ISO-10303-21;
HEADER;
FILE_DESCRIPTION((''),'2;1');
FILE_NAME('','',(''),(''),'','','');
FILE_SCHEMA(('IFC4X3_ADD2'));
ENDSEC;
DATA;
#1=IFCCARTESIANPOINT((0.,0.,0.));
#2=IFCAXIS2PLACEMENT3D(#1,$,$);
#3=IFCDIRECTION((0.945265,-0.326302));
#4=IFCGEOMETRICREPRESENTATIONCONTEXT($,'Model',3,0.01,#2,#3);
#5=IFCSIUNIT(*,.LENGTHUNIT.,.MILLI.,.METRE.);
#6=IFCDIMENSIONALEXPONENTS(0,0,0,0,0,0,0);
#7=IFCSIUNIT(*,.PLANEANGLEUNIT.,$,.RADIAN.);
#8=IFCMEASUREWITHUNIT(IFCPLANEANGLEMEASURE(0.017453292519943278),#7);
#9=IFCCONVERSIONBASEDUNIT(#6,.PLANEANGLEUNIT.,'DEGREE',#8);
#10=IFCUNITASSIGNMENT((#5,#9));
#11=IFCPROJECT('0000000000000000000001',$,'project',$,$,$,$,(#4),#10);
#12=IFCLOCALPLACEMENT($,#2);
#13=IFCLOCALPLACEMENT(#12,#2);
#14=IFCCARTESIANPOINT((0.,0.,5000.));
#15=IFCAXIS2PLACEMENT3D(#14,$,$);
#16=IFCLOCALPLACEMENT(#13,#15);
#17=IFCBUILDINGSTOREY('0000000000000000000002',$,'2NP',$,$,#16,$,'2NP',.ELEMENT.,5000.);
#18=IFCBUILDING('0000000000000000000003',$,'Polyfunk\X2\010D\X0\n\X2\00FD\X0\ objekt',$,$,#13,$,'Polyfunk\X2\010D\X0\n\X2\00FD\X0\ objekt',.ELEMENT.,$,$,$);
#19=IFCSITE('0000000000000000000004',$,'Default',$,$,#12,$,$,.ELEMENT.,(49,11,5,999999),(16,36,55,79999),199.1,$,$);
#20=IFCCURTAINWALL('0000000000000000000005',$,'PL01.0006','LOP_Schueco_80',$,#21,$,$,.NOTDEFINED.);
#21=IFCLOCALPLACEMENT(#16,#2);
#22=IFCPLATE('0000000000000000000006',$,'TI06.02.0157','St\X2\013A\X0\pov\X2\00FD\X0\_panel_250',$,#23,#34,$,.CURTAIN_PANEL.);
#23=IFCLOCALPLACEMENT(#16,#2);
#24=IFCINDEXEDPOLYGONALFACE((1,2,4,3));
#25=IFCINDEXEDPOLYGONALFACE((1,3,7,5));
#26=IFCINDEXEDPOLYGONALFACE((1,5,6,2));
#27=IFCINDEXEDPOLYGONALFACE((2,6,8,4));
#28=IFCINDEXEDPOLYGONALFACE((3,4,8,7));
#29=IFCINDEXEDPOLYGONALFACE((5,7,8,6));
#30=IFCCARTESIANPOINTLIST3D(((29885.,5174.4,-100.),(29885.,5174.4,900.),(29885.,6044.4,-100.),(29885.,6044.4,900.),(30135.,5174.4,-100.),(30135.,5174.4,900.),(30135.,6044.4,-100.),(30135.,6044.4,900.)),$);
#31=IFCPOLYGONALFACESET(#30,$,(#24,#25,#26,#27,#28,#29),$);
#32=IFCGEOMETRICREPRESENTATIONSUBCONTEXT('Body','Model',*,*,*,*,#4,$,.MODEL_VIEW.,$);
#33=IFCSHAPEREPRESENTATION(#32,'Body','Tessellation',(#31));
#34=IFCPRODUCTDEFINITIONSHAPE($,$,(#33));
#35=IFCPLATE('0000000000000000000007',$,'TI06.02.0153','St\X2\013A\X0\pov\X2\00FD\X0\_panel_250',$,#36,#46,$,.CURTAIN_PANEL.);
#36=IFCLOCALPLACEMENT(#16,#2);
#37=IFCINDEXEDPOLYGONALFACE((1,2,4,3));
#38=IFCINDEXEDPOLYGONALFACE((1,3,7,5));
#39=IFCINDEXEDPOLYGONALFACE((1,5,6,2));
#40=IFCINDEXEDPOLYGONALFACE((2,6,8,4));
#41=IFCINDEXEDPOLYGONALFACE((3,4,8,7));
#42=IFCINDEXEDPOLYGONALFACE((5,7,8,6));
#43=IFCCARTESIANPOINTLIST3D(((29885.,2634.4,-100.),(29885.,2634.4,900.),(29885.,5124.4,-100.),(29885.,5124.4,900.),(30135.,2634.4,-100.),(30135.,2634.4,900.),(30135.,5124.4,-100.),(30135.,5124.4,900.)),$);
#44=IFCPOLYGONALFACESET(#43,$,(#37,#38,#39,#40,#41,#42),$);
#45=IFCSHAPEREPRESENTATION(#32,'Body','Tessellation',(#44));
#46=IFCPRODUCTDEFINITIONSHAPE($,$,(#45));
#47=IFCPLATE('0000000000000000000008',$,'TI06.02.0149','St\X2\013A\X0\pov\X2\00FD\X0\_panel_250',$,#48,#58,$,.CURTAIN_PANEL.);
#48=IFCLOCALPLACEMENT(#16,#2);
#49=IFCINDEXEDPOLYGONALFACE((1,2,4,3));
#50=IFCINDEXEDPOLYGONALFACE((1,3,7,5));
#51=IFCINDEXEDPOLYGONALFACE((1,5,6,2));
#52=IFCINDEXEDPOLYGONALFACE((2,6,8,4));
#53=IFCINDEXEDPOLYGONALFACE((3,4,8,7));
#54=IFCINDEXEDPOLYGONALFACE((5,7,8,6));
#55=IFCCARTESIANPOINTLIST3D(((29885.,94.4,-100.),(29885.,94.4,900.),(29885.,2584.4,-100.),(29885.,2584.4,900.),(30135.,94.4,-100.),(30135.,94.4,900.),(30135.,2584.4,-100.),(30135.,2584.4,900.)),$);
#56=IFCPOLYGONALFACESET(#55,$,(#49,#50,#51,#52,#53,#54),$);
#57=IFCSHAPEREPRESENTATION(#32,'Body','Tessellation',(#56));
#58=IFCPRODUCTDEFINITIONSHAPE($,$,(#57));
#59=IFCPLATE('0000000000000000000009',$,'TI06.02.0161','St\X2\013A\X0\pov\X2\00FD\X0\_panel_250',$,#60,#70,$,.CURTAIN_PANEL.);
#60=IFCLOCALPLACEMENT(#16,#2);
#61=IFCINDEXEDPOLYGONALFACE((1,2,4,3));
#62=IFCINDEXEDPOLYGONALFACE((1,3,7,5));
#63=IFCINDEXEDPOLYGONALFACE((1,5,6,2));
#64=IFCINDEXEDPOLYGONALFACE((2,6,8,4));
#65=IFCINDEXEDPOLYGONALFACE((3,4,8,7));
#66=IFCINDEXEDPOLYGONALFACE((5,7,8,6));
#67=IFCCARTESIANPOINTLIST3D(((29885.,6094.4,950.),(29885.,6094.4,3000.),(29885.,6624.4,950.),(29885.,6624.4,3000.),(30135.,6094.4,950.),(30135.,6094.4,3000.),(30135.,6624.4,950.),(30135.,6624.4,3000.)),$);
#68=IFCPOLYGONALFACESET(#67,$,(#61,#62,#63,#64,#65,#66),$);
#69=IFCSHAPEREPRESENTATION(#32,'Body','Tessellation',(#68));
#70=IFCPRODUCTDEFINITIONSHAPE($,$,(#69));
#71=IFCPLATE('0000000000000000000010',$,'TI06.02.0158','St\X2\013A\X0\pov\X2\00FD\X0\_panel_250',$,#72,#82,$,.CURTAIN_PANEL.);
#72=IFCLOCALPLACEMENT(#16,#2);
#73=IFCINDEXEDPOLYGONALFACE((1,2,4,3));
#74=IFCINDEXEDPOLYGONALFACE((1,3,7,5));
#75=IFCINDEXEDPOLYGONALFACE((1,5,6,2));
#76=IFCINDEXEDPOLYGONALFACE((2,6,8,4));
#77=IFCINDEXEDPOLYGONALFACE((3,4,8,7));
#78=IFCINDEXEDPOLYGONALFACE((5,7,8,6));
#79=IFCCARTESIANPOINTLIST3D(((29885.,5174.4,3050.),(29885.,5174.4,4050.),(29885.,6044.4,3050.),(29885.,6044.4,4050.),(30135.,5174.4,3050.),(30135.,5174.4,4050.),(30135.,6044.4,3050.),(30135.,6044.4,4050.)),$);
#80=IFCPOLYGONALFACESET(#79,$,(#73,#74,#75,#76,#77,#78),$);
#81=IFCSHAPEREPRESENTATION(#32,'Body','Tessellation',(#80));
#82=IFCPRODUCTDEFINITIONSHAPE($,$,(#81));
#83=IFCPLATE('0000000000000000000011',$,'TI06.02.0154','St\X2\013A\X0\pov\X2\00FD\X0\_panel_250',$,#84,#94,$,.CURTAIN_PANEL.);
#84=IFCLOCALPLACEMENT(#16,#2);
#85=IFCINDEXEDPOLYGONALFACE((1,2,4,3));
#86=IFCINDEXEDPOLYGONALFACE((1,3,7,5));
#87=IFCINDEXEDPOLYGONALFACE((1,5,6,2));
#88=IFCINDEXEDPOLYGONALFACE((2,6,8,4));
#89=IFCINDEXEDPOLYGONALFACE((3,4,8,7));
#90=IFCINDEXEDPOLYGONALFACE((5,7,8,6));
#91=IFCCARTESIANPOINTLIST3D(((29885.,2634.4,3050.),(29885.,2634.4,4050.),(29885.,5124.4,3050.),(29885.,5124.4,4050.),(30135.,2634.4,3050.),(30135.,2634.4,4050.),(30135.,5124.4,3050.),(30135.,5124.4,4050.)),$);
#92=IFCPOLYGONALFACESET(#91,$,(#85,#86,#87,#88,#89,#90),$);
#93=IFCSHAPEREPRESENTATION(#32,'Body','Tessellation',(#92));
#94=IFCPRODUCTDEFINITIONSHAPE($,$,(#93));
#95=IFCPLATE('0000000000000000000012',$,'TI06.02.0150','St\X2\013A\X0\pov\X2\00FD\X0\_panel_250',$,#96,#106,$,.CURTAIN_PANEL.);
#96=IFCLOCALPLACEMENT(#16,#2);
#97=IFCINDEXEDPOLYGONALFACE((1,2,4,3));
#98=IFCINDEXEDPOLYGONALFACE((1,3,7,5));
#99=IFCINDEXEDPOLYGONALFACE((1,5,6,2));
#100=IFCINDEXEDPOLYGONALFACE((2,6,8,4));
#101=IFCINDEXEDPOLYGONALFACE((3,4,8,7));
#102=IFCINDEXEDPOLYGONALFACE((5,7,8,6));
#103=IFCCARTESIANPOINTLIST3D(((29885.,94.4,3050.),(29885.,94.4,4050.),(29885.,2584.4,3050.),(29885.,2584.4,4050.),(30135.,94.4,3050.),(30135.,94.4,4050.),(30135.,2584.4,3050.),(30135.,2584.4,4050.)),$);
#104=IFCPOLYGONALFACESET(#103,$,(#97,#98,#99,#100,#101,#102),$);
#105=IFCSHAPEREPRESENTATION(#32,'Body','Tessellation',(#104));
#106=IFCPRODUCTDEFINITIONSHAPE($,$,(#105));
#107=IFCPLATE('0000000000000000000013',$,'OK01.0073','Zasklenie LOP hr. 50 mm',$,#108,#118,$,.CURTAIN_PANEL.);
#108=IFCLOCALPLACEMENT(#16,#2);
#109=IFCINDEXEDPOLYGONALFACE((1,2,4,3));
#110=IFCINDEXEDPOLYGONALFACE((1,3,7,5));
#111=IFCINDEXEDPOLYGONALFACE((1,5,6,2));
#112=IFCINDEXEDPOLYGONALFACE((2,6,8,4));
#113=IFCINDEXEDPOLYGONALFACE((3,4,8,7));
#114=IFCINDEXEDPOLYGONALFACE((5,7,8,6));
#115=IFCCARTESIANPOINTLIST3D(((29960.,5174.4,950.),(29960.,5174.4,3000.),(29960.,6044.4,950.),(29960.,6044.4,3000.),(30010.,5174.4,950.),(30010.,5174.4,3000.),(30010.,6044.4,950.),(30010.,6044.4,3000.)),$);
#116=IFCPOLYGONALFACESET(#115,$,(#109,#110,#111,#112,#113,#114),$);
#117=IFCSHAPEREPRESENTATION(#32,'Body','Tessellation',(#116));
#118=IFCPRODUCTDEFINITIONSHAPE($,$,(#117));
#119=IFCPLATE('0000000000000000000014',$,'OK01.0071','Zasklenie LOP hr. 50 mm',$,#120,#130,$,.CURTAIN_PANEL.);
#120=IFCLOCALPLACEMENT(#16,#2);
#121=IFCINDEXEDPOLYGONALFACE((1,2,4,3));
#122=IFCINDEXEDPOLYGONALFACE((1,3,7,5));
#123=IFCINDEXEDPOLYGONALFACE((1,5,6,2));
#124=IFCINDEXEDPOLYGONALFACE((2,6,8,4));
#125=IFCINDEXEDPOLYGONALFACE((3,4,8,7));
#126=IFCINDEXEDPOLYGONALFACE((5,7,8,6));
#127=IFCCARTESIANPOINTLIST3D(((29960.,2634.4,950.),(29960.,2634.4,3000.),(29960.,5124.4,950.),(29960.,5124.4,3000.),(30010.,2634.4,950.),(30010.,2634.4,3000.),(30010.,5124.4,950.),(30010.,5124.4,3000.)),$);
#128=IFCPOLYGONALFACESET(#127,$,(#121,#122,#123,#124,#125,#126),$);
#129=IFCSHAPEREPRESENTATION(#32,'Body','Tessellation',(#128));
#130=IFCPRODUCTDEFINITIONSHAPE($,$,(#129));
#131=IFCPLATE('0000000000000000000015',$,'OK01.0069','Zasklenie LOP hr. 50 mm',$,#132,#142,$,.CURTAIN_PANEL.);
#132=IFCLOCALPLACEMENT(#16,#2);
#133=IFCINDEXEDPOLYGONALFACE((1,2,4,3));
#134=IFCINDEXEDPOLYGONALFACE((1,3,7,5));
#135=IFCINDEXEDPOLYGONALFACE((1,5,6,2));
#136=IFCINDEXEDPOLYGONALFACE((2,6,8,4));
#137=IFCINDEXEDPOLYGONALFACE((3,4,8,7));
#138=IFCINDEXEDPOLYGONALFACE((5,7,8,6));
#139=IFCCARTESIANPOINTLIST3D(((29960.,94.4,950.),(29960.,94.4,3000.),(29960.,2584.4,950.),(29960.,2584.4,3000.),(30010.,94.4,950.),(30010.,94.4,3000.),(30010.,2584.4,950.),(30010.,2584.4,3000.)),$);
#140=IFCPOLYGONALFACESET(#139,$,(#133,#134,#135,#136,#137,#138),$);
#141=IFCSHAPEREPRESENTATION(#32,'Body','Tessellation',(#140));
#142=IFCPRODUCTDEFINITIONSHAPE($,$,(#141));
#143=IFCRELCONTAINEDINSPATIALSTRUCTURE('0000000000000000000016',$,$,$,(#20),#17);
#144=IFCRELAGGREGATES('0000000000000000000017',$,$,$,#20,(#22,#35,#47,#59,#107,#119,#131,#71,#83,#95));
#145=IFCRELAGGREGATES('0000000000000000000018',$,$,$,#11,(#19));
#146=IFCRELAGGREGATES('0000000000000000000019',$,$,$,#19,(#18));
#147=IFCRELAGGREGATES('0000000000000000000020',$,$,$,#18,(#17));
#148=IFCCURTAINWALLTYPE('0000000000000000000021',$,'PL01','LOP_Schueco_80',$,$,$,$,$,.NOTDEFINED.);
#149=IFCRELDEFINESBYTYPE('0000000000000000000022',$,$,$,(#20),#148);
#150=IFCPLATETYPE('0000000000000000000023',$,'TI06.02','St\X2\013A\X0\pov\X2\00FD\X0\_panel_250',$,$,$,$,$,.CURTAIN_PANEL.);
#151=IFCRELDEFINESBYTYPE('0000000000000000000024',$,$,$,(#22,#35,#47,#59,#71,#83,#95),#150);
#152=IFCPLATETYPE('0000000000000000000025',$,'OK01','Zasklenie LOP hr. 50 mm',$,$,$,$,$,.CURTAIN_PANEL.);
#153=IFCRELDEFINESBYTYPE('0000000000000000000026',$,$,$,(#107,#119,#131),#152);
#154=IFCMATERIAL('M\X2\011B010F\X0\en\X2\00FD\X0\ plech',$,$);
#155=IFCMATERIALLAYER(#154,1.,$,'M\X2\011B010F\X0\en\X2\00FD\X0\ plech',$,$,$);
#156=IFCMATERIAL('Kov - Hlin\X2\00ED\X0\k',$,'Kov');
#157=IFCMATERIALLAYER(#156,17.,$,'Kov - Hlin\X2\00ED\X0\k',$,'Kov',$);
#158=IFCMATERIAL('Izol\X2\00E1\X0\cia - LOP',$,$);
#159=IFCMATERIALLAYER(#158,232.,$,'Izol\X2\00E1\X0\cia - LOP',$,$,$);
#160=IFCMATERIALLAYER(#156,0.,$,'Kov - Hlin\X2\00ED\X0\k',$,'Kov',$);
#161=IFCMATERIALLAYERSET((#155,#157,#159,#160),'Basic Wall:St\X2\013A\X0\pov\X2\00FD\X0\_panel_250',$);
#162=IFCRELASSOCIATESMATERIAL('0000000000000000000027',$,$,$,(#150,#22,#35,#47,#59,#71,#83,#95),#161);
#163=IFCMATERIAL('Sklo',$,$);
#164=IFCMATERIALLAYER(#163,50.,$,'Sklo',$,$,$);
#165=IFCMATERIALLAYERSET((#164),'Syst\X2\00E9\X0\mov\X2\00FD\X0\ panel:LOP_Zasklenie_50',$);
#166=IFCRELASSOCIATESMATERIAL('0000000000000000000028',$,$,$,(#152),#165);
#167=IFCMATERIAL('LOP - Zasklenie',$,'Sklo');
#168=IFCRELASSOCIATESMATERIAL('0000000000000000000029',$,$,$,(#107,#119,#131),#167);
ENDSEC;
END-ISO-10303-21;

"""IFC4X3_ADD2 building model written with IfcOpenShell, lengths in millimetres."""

from ifc_helpers import new_model, entity, si_unit, converted_unit, direction, frame, frame_2d, origin, origin_2d_with_axis, place, context, subcontext, project, spatial, rectangle, extrude, source, transform, mapped, material, layer, layer_set, layer_usage, type_object, type_shapes, element, aggregate, save


model = new_model("IFC4X3_ADD2")

# Units and contexts
model_context = context("Model", 3, precision=0.01, world=origin(), true_north=direction((0.945265, -0.326302)))
body_context = subcontext(model_context, "Body", "Model", "MODEL_VIEW")
ifc_project = project(units=[si_unit("LENGTHUNIT", "METRE", prefix="MILLI"), converted_unit("PLANEANGLEUNIT", "DEGREE", entity("IfcPlaneAngleMeasure", 0.017453292519943278), si_unit("PLANEANGLEUNIT", "RADIAN"), dimensions=[0, 0, 0, 0, 0, 0, 0])], contexts=[model_context])

# Site, building, storey
site_placement = place(None, origin())
site = spatial("IfcSite", under=ifc_project, at=site_placement, Name="Default", CompositionType="ELEMENT", RefLatitude=(49, 11, 5, 999999), RefLongitude=(16, 36, 55, 79999), RefElevation=199.1)
building_placement = place(site_placement, origin())
building = spatial("IfcBuilding", under=site, at=building_placement, Name="Polyfunkčný objekt", LongName="Polyfunkčný objekt", CompositionType="ELEMENT")
storey_placement = place(building_placement, frame((0.0, 0.0, 5000.0)))
storey = spatial("IfcBuildingStorey", under=building, at=storey_placement, Name="2NP", LongName="2NP", CompositionType="ELEMENT", Elevation=5000.0)

# Shared definitions
curtain_wall_type = type_object("IfcCurtainWallType", Name="PL01", Description="LOP_Schueco_80", PredefinedType="NOTDEFINED")

# Curtain wall
curtain_wall_1_placement = place(storey_placement, frame((0.0, 0.0, -5000.0)))
curtain_wall_1 = element("IfcCurtainWall", 1, at=curtain_wall_1_placement, inside=storey, type_object=curtain_wall_type, Name="PL01.0006", Description="LOP_Schueco_80", PredefinedType="NOTDEFINED")

# Plates
ifc_material_1 = material(Name="Měďený plech")
ifc_layer_1 = layer(ifc_material_1, 1.0, Name="Měďený plech")
ifc_material_2 = material(Name="Kov - Hliník", Category="Kov")
ifc_layer_2 = layer(ifc_material_2, 17.0, Name="Kov - Hliník", Category="Kov")
ifc_material_3 = material(Name="Izolácia - LOP")
ifc_layer_3 = layer(ifc_material_3, 232.0, Name="Izolácia - LOP")
ifc_layer_4 = layer(ifc_material_2, 0.0, Name="Kov - Hliník", Category="Kov")
ifc_layer_set_1 = layer_set([ifc_layer_1, ifc_layer_2, ifc_layer_3, ifc_layer_4], Name="Basic Wall:Stĺpový_panel_250")
ifc_layer_usage_1 = layer_usage(ifc_layer_set_1, "AXIS2", "POSITIVE", -125.0)
plate_type_1 = type_object("IfcPlateType", Name="TI06.02", Description="Stĺpový_panel_250", PredefinedType="CURTAIN_PANEL", material=ifc_layer_set_1)
plate_1_placement = place(storey_placement, frame((30010.0, 6044.4, -100.0), z_axis=(0.0, 0.0, 1.0), x_axis=(0.0, -1.0, 0.0)))
plate_1 = element("IfcPlate", 2, at=plate_1_placement, type_object=plate_type_1, material=ifc_layer_usage_1, Name="TI06.02.0157", Description="Stĺpový_panel_250", PredefinedType="CURTAIN_PANEL", context=body_context, shape_type="SweptSolid", body=[
    extrude(rectangle(XDim=250.0, YDim=870.0, at=frame_2d((0.0, 0.0), x_axis=(1.0, 0.0))), frame((435.0, 0.0, 0.0), z_axis=(0.0, 0.0, 1.0), x_axis=(0.0, 1.0, 0.0)), (0.0, 0.0, 1.0), 1000.0),
])
ifc_layer_usage_2 = layer_usage(ifc_layer_set_1, "AXIS2", "POSITIVE", -125.0)
plate_2_placement = place(storey_placement, frame((30010.0, 5124.4, -100.0), z_axis=(0.0, 0.0, 1.0), x_axis=(0.0, -1.0, 0.0)))
plate_2 = element("IfcPlate", 3, at=plate_2_placement, type_object=plate_type_1, material=ifc_layer_usage_2, Name="TI06.02.0153", Description="Stĺpový_panel_250", PredefinedType="CURTAIN_PANEL", context=body_context, shape_type="SweptSolid", body=[
    extrude(rectangle(XDim=250.0, YDim=2490.0, at=frame_2d((0.0, 0.0), x_axis=(1.0, 0.0))), frame((1245.0, 0.0, 0.0), z_axis=(0.0, 0.0, 1.0), x_axis=(0.0, 1.0, 0.0)), (0.0, 0.0, 1.0), 1000.0),
])
ifc_layer_usage_3 = layer_usage(ifc_layer_set_1, "AXIS2", "POSITIVE", -125.0)
plate_3_placement = place(storey_placement, frame((30010.0, 2584.4, -100.0), z_axis=(0.0, 0.0, 1.0), x_axis=(0.0, -1.0, 0.0)))
plate_3 = element("IfcPlate", 4, at=plate_3_placement, type_object=plate_type_1, material=ifc_layer_usage_3, Name="TI06.02.0149", Description="Stĺpový_panel_250", PredefinedType="CURTAIN_PANEL", context=body_context, shape_type="SweptSolid", body=[
    extrude(rectangle(XDim=250.0, YDim=2490.0, at=frame_2d((0.0, 0.0), x_axis=(1.0, 0.0))), frame((1245.0, 0.0, 0.0), z_axis=(0.0, 0.0, 1.0), x_axis=(0.0, 1.0, 0.0)), (0.0, 0.0, 1.0), 1000.0),
])
ifc_layer_usage_4 = layer_usage(ifc_layer_set_1, "AXIS2", "POSITIVE", -125.0)
plate_4_placement = place(storey_placement, frame((30010.0, 6624.4, 950.0), z_axis=(0.0, 0.0, 1.0), x_axis=(0.0, -1.0, 0.0)))
plate_4 = element("IfcPlate", 5, at=plate_4_placement, type_object=plate_type_1, material=ifc_layer_usage_4, Name="TI06.02.0161", Description="Stĺpový_panel_250", PredefinedType="CURTAIN_PANEL", context=body_context, shape_type="SweptSolid", body=[
    extrude(rectangle(XDim=250.0, YDim=530.0, at=frame_2d((0.0, 0.0), x_axis=(1.0, 0.0))), frame((265.0, 0.0, 0.0), z_axis=(0.0, 0.0, 1.0), x_axis=(0.0, 1.0, 0.0)), (0.0, 0.0, 1.0), 2050.0),
])
ifc_layer_usage_5 = layer_usage(ifc_layer_set_1, "AXIS2", "POSITIVE", -125.0)
plate_5_placement = place(storey_placement, frame((30010.0, 6044.4, 3050.0), z_axis=(0.0, 0.0, 1.0), x_axis=(0.0, -1.0, 0.0)))
plate_5 = element("IfcPlate", 6, at=plate_5_placement, type_object=plate_type_1, material=ifc_layer_usage_5, Name="TI06.02.0158", Description="Stĺpový_panel_250", PredefinedType="CURTAIN_PANEL", context=body_context, shape_type="SweptSolid", body=[
    extrude(rectangle(XDim=250.0, YDim=870.0, at=frame_2d((0.0, 0.0), x_axis=(1.0, 0.0))), frame((435.0, 0.0, 0.0), z_axis=(0.0, 0.0, 1.0), x_axis=(0.0, 1.0, 0.0)), (0.0, 0.0, 1.0), 1000.0),
])
ifc_layer_usage_6 = layer_usage(ifc_layer_set_1, "AXIS2", "POSITIVE", -125.0)
plate_6_placement = place(storey_placement, frame((30010.0, 5124.4, 3050.0), z_axis=(0.0, 0.0, 1.0), x_axis=(0.0, -1.0, 0.0)))
plate_6 = element("IfcPlate", 7, at=plate_6_placement, type_object=plate_type_1, material=ifc_layer_usage_6, Name="TI06.02.0154", Description="Stĺpový_panel_250", PredefinedType="CURTAIN_PANEL", context=body_context, shape_type="SweptSolid", body=[
    extrude(rectangle(XDim=250.0, YDim=2490.0, at=frame_2d((0.0, 0.0), x_axis=(1.0, 0.0))), frame((1245.0, 0.0, 0.0), z_axis=(0.0, 0.0, 1.0), x_axis=(0.0, 1.0, 0.0)), (0.0, 0.0, 1.0), 1000.0),
])
ifc_layer_usage_7 = layer_usage(ifc_layer_set_1, "AXIS2", "POSITIVE", -125.0)
plate_7_placement = place(storey_placement, frame((30010.0, 2584.4, 3050.0), z_axis=(0.0, 0.0, 1.0), x_axis=(0.0, -1.0, 0.0)))
plate_7 = element("IfcPlate", 8, at=plate_7_placement, type_object=plate_type_1, material=ifc_layer_usage_7, Name="TI06.02.0150", Description="Stĺpový_panel_250", PredefinedType="CURTAIN_PANEL", context=body_context, shape_type="SweptSolid", body=[
    extrude(rectangle(XDim=250.0, YDim=2490.0, at=frame_2d((0.0, 0.0), x_axis=(1.0, 0.0))), frame((1245.0, 0.0, 0.0), z_axis=(0.0, 0.0, 1.0), x_axis=(0.0, 1.0, 0.0)), (0.0, 0.0, 1.0), 1000.0),
])
ifc_material_4 = material(Name="LOP - Zasklenie", Category="Sklo")
ifc_material_5 = material(Name="Sklo")
ifc_layer_5 = layer(ifc_material_5, 50.0, Name="Sklo")
ifc_layer_set_2 = layer_set([ifc_layer_5], Name="Systémový panel:LOP_Zasklenie_50")
plate_type_2 = type_object("IfcPlateType", Name="OK01", Description="Zasklenie LOP hr. 50 mm", PredefinedType="CURTAIN_PANEL", material=ifc_layer_set_2)
shared_shape_1 = source(origin(), body_context, "Body", "SweptSolid", [
    extrude(rectangle(XDim=50.0, YDim=870.0, at=origin_2d_with_axis()), frame((0.0, -25.0, 0.0), z_axis=(0.0, 0.0, 1.0), x_axis=(0.0, 1.0, 0.0)), (0.0, 0.0, 1.0), 2050.0),
])
plate_8_placement = place(curtain_wall_1_placement, frame((30010.0, 5609.4, 5950.0), z_axis=(0.0, 0.0, 1.0), x_axis=(0.0, -1.0, 0.0)))
plate_8 = element("IfcPlate", 9, at=plate_8_placement, type_object=plate_type_2, material=ifc_material_4, Name="OK01.0073", Description="Zasklenie LOP hr. 50 mm", PredefinedType="CURTAIN_PANEL", context=body_context, shape_type="MappedRepresentation", body=[
    mapped(shared_shape_1, transform((0.0, 0.0, 0.0), scale=1.0)),
])
shared_shape_2 = source(origin(), body_context, "Body", "SweptSolid", [
    extrude(rectangle(XDim=50.0, YDim=2490.0, at=origin_2d_with_axis()), frame((0.0, -25.0, 0.0), z_axis=(0.0, 0.0, 1.0), x_axis=(0.0, 1.0, 0.0)), (0.0, 0.0, 1.0), 2050.0),
])
type_shapes(plate_type_2, [shared_shape_1, shared_shape_2])
plate_9_placement = place(curtain_wall_1_placement, frame((30010.0, 3879.4, 5950.0), z_axis=(0.0, 0.0, 1.0), x_axis=(0.0, -1.0, 0.0)))
plate_9 = element("IfcPlate", 10, at=plate_9_placement, type_object=plate_type_2, material=ifc_material_4, Name="OK01.0071", Description="Zasklenie LOP hr. 50 mm", PredefinedType="CURTAIN_PANEL", context=body_context, shape_type="MappedRepresentation", body=[
    mapped(shared_shape_2, transform((0.0, 0.0, 0.0), scale=1.0)),
])
plate_10_placement = place(curtain_wall_1_placement, frame((30010.0, 1339.4, 5950.0), z_axis=(0.0, 0.0, 1.0), x_axis=(0.0, -1.0, 0.0)))
plate_10 = element("IfcPlate", 11, at=plate_10_placement, type_object=plate_type_2, material=ifc_material_4, Name="OK01.0069", Description="Zasklenie LOP hr. 50 mm", PredefinedType="CURTAIN_PANEL", context=body_context, shape_type="MappedRepresentation", body=[
    mapped(shared_shape_2, transform((0.0, 0.0, 0.0), scale=1.0)),
])
aggregate(curtain_wall_1, [plate_1, plate_2, plate_3, plate_4, plate_8, plate_9, plate_10, plate_5, plate_6, plate_7])

save(model, "model.ifc")
